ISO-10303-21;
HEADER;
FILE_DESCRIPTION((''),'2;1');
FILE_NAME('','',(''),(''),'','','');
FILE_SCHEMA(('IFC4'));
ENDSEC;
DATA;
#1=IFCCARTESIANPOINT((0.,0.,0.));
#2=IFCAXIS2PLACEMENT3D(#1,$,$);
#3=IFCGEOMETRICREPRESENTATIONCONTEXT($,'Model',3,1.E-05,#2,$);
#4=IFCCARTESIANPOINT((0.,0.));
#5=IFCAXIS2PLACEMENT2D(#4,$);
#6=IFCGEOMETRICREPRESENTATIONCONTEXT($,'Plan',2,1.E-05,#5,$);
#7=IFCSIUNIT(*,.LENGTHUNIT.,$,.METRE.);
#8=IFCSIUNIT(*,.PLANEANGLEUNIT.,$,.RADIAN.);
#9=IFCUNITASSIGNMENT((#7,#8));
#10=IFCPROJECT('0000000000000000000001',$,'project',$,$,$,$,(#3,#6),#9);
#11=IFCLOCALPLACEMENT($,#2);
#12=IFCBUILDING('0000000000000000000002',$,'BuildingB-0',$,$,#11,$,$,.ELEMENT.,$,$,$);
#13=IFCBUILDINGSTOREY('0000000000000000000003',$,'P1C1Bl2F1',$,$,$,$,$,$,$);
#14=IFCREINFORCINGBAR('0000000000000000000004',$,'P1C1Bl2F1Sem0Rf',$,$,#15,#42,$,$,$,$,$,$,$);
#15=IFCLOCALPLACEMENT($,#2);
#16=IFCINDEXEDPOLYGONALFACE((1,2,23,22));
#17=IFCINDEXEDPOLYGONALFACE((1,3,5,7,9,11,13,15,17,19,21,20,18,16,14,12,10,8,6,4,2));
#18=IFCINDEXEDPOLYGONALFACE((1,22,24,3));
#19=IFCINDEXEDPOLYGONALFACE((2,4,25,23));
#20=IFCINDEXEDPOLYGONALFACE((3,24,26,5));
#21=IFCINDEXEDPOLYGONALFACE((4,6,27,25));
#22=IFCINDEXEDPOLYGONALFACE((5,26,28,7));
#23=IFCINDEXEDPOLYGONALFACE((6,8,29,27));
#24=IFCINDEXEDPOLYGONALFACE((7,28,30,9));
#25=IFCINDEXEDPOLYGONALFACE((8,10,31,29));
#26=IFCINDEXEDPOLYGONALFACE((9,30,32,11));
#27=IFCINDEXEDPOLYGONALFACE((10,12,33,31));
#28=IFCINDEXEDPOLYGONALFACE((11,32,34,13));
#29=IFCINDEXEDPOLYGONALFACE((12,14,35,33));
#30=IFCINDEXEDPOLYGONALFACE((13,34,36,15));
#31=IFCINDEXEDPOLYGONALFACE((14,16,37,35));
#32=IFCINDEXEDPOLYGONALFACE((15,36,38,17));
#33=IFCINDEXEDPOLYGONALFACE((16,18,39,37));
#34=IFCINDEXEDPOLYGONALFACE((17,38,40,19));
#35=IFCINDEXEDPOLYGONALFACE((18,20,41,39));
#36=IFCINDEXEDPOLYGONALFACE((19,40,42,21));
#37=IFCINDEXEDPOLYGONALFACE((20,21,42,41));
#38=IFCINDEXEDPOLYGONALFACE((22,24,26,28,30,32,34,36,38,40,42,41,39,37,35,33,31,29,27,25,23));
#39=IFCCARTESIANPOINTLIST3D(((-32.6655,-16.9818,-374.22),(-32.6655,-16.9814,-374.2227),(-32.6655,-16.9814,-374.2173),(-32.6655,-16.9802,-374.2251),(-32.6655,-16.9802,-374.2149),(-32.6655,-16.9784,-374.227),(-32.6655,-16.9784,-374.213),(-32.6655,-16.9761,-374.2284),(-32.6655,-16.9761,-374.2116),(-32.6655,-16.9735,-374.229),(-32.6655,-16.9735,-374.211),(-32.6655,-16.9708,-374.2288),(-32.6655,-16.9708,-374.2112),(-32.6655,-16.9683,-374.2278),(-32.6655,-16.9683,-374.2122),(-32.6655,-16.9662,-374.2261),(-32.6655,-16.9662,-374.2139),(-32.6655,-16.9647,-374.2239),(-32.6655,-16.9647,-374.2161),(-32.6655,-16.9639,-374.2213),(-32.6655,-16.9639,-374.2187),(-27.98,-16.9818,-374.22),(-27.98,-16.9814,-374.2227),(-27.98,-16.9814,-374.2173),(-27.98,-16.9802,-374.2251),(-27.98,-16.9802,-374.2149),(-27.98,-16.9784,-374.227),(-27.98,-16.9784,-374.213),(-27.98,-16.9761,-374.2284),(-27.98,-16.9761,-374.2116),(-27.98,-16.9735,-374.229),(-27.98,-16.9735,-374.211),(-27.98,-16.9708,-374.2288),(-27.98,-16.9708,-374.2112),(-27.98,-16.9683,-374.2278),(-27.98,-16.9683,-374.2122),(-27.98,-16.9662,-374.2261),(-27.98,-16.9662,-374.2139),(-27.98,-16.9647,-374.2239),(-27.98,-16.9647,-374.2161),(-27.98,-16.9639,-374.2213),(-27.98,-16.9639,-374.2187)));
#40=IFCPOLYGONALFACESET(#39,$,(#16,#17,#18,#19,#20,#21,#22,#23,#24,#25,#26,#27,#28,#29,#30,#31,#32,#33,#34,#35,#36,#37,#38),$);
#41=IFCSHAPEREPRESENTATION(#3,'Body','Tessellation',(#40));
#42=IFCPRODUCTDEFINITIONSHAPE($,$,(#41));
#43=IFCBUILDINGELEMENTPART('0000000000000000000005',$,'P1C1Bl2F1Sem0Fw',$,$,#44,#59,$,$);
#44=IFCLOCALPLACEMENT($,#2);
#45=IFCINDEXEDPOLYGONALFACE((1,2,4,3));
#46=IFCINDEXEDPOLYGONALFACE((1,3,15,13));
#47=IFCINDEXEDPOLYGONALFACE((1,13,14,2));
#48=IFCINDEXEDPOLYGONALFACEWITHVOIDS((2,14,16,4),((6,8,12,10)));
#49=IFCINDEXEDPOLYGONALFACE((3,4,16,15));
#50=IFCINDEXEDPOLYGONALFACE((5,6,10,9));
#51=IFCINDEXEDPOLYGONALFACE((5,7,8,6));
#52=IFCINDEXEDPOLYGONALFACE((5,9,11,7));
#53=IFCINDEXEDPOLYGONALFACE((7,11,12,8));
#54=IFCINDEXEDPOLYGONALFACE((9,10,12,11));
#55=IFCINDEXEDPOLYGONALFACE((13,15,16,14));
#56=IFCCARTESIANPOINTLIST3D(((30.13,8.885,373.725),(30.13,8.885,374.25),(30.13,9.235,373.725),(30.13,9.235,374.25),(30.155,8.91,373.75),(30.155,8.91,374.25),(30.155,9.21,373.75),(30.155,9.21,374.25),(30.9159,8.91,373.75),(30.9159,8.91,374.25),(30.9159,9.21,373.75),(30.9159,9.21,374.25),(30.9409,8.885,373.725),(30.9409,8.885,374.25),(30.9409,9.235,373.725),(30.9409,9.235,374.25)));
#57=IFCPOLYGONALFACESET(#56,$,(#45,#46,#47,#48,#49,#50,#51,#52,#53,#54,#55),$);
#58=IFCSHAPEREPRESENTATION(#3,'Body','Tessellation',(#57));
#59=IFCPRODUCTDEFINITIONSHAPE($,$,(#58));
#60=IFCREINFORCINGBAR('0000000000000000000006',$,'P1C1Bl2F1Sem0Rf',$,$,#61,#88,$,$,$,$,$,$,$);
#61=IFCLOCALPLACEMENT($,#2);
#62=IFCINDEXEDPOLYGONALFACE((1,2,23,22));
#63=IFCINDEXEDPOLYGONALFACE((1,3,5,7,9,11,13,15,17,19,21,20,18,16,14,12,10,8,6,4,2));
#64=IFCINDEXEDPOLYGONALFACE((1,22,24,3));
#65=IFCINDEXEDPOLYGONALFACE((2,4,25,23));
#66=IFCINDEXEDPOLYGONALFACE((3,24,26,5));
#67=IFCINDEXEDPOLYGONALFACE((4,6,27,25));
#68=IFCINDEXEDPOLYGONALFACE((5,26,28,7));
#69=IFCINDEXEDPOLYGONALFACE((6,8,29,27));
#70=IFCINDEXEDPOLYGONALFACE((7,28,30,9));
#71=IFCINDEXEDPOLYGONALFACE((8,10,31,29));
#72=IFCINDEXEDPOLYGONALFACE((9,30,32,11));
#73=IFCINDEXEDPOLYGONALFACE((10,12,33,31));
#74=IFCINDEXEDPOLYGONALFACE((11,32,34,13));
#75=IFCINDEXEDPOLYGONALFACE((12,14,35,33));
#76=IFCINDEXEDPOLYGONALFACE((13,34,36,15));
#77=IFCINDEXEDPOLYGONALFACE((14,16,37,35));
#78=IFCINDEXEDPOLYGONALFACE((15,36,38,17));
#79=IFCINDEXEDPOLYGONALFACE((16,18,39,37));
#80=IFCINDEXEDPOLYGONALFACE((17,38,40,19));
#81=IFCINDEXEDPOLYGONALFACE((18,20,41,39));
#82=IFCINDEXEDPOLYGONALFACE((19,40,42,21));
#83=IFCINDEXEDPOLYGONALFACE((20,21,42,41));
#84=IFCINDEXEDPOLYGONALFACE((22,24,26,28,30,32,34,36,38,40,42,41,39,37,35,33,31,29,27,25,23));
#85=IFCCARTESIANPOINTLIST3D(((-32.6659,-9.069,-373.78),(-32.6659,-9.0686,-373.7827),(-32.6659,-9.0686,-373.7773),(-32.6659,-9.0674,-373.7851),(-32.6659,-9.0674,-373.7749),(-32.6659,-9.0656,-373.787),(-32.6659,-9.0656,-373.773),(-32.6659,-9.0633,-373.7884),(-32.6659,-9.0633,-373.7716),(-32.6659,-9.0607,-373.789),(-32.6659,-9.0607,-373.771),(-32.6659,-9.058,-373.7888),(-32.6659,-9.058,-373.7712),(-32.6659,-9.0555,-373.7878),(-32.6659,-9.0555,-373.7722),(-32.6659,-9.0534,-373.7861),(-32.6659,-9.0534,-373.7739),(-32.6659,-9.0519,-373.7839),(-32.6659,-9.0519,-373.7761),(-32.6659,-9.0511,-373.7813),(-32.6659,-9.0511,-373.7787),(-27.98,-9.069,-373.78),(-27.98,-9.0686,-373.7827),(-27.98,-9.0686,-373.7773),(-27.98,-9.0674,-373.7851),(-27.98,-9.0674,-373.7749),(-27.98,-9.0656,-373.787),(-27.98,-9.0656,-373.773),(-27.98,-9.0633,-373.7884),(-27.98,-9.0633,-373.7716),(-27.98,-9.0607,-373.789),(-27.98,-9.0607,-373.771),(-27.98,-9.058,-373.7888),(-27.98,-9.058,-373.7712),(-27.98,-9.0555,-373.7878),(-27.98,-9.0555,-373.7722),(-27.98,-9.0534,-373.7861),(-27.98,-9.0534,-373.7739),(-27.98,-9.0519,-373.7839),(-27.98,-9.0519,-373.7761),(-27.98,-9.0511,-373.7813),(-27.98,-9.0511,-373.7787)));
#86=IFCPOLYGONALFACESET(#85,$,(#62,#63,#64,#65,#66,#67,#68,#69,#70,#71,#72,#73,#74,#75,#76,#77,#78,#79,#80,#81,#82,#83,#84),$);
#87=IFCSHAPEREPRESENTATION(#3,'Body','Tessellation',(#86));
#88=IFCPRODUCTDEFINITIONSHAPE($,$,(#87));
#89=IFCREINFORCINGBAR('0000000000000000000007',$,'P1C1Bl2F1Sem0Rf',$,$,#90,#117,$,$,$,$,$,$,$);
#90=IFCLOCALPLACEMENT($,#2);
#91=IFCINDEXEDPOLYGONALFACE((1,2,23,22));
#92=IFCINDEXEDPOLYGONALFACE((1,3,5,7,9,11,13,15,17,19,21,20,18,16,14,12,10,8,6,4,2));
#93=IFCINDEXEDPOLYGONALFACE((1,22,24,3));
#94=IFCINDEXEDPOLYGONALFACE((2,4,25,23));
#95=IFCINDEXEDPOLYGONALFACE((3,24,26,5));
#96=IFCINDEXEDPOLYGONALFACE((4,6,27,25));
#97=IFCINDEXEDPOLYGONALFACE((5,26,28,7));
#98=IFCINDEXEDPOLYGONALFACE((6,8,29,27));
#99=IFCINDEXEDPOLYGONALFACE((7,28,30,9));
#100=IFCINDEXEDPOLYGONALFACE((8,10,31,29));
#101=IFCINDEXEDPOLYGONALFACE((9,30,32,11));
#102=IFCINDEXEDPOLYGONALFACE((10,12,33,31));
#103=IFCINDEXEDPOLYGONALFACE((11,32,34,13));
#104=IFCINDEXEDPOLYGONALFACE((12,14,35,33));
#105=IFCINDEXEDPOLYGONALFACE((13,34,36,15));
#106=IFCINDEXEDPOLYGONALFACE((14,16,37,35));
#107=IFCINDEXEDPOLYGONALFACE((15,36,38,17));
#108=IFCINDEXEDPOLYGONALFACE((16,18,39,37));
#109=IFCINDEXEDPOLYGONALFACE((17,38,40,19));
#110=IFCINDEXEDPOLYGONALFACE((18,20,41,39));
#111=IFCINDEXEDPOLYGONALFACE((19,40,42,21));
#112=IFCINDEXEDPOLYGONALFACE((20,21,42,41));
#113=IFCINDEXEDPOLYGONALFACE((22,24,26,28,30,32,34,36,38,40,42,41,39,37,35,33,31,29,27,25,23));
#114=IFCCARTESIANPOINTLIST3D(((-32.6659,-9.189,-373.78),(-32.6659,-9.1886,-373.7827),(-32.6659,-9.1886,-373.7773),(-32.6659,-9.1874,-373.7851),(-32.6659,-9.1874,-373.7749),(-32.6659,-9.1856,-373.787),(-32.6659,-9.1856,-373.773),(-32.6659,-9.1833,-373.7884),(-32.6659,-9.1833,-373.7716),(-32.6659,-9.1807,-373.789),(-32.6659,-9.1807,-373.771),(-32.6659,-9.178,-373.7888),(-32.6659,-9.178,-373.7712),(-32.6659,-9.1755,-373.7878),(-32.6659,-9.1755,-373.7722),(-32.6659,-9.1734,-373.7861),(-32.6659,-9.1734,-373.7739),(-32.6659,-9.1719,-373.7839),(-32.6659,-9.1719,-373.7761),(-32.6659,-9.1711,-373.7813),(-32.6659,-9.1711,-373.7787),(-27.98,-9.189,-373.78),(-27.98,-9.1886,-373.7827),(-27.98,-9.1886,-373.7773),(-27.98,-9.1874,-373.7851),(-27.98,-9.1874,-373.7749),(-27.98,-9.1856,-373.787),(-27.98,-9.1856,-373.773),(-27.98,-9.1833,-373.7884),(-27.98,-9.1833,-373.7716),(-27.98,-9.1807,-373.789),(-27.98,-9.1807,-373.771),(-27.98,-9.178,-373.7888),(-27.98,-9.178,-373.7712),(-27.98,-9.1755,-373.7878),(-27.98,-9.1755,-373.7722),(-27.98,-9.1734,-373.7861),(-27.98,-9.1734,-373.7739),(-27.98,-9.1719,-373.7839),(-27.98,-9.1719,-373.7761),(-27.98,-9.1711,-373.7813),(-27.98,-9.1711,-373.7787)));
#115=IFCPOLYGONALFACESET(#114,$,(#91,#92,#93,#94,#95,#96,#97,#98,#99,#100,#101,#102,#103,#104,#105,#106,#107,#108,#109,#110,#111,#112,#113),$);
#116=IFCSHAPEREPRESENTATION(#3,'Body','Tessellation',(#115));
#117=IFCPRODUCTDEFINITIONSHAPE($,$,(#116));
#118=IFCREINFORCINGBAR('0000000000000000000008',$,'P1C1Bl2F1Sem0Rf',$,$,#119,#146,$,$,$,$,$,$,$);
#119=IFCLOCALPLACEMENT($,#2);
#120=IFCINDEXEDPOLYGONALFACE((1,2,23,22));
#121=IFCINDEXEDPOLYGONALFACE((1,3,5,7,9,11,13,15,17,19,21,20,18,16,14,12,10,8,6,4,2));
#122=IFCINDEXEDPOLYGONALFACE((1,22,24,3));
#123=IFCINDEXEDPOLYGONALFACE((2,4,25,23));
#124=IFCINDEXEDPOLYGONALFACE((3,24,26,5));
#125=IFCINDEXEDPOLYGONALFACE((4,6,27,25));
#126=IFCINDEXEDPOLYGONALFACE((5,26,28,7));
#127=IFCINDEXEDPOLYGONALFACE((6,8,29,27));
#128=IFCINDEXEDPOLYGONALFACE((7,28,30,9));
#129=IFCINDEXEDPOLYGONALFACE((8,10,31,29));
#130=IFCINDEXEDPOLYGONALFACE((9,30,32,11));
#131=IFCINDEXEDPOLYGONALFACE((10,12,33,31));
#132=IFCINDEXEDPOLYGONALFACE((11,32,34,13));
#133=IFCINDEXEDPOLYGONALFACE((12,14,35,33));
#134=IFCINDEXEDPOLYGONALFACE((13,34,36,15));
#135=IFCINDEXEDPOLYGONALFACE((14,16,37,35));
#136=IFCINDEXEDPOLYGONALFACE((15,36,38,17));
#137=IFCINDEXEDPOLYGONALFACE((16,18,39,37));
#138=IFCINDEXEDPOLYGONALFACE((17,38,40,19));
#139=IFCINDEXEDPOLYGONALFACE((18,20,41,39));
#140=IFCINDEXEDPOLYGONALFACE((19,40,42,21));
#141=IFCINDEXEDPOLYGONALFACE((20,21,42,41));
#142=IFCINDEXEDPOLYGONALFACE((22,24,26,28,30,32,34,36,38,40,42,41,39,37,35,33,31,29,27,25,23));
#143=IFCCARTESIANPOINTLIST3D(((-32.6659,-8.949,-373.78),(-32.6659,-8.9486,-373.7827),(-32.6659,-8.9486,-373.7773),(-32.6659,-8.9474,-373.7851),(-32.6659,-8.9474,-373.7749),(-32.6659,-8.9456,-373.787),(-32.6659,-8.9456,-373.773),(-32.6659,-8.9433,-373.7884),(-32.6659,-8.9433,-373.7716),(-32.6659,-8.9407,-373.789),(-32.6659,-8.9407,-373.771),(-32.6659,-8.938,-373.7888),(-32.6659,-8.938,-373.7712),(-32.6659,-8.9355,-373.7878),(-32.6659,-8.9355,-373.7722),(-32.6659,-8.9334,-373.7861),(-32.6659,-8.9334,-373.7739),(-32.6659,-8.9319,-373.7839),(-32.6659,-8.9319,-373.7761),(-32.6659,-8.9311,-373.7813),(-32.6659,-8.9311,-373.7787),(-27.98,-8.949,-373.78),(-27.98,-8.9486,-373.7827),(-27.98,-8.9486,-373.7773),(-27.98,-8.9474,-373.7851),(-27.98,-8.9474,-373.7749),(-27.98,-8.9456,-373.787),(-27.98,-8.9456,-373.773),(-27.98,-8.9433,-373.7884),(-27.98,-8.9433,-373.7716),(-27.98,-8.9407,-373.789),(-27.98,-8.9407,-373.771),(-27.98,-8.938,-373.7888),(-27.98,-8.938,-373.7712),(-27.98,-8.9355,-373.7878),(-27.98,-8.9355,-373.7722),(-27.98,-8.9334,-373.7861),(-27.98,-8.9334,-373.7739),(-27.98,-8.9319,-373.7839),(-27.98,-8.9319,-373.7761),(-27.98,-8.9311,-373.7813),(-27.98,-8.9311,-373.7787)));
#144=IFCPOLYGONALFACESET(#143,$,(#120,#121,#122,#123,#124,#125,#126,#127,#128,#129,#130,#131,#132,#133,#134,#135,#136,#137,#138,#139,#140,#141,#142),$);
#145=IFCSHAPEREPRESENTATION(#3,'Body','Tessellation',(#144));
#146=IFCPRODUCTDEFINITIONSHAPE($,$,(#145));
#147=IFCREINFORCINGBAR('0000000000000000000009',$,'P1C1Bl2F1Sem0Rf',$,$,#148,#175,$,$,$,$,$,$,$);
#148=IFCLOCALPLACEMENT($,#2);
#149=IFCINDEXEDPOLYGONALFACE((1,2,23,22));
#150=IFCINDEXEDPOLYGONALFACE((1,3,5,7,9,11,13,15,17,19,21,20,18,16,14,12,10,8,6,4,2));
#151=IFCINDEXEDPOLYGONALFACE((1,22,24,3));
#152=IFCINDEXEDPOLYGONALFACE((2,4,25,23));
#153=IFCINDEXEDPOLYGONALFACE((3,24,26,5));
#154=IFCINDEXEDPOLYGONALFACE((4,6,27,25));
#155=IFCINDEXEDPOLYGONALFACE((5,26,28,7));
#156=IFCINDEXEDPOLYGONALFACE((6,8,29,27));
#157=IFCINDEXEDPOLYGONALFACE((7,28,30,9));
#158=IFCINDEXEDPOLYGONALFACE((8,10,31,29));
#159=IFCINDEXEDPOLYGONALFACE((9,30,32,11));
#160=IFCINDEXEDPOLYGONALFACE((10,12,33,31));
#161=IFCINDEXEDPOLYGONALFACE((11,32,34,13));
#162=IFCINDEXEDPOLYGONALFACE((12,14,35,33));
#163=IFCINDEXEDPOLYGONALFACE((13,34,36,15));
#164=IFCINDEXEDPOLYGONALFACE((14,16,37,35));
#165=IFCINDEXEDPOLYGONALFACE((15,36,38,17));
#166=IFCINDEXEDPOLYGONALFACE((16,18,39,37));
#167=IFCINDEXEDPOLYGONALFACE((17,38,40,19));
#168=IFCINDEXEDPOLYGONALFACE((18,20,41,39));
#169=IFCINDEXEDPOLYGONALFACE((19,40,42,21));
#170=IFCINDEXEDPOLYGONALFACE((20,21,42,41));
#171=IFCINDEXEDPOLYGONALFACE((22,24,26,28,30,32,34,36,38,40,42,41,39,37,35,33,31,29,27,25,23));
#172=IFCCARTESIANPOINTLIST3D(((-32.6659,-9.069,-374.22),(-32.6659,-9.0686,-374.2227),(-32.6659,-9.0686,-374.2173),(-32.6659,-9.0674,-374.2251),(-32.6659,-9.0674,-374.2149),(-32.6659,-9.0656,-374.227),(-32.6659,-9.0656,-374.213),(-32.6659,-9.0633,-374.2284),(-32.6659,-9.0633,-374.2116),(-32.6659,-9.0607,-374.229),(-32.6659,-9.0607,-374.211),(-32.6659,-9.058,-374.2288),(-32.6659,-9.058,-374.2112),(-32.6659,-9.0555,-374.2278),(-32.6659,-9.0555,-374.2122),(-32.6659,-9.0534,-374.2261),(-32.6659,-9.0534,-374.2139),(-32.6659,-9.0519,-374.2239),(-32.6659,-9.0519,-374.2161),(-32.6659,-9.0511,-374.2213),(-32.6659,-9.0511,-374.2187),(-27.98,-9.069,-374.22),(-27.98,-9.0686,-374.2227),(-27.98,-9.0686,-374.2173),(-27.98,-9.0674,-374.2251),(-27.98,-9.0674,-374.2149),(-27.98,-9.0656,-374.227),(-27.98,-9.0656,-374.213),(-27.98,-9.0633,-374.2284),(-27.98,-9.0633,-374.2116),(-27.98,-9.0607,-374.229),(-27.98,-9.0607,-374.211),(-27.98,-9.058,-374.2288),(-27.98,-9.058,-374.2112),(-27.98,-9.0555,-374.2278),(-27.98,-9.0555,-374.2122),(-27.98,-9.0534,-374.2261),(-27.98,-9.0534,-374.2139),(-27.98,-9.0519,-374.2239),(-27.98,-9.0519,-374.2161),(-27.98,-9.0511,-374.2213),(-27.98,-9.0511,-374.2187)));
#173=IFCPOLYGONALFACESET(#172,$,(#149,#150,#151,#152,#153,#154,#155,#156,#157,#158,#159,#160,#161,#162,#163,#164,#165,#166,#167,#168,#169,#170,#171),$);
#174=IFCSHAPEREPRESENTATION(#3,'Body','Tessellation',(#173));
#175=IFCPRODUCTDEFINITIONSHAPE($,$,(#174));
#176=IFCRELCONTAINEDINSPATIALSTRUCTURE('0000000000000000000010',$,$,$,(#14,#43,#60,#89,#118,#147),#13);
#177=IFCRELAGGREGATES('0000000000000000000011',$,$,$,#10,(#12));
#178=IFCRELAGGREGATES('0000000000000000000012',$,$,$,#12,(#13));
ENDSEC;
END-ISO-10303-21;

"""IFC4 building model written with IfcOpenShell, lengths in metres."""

from ifc_helpers import new_model, entity, si_unit, origin, origin_2d, place, context, project, spatial, polyline, outline, extrude, element, save


model = new_model("IFC4")

# Units and contexts
model_context = context("Model", 3, precision=1e-05, world=origin())
plan_context = context("Plan", 2, precision=1e-05, world=origin_2d())
ifc_project = project(units=[si_unit("LENGTHUNIT", "METRE"), si_unit("PLANEANGLEUNIT", "RADIAN")], contexts=[model_context, plan_context])

# Building, storey
building_placement = place(None, origin())
building = spatial("IfcBuilding", under=ifc_project, at=building_placement, Name="BuildingB-0", CompositionType="ELEMENT")
storey = spatial("IfcBuildingStorey", under=building, Name="P1C1Bl2F1")

# Reinforcing bar
element("IfcReinforcingBar", 1, inside=storey, Name="P1C1Bl2F1Sem0Rf", context=model_context, shape_type="SweptSolid", body=[
    entity("IfcSurfaceCurveSweptAreaSolid", entity("IfcCircleProfileDef", "AREA", None, None, 0.009), None, entity("IfcPolyline", [entity("IfcCartesianPoint", [32.6655, 16.9728, 374.22]), entity("IfcCartesianPoint", [27.98, 16.9728, 374.22])]), None, None, entity("IfcPlane", entity("IfcAxis2Placement3D", entity("IfcCartesianPoint", [32.6655, 16.9728, 374.22]), entity("IfcDirection", [0.0, 0.0, 1.0]), entity("IfcDirection", [1.0, 0.0, 0.0])))),
])

# Building element part, opening
building_element_part_1 = element("IfcBuildingElementPart", 2, inside=storey, Name="P1C1Bl2F1Sem0Fw", context=model_context, shape_type="SweptSolid", body=[
    extrude(outline(polyline([(30.13, 8.885, 373.725), (30.9409, 8.885, 373.725), (30.9409, 9.235, 373.725), (30.13, 9.235, 373.725), (30.13, 8.885, 373.725)])), None, (0.0, 0.0, 1.0), 0.525),
])
element("IfcOpeningElement", 3, inside=storey, cuts=building_element_part_1, context=model_context, shape_type="SweptSolid", body=[
    extrude(outline(polyline([(30.155, 8.91, 373.75), (30.9159, 8.91, 373.75), (30.9159, 9.21, 373.75), (30.155, 9.21, 373.75), (30.155, 8.91, 373.75)])), None, (0.0, 0.0, 1.0), 0.5),
])

# Reinforcing bars
element("IfcReinforcingBar", 4, inside=storey, Name="P1C1Bl2F1Sem0Rf", context=model_context, shape_type="SweptSolid", body=[
    entity("IfcSurfaceCurveSweptAreaSolid", entity("IfcCircleProfileDef", "AREA", None, None, 0.009), None, entity("IfcPolyline", [entity("IfcCartesianPoint", [32.6659, 9.06, 373.78]), entity("IfcCartesianPoint", [27.98, 9.06, 373.78])]), None, None, entity("IfcPlane", entity("IfcAxis2Placement3D", entity("IfcCartesianPoint", [32.6659, 9.06, 373.78]), entity("IfcDirection", [0.0, 0.0, 1.0]), entity("IfcDirection", [1.0, 0.0, 0.0])))),
])
element("IfcReinforcingBar", 5, inside=storey, Name="P1C1Bl2F1Sem0Rf", context=model_context, shape_type="SweptSolid", body=[
    entity("IfcSurfaceCurveSweptAreaSolid", entity("IfcCircleProfileDef", "AREA", None, None, 0.009), None, entity("IfcPolyline", [entity("IfcCartesianPoint", [32.6659, 9.18, 373.78]), entity("IfcCartesianPoint", [27.98, 9.18, 373.78])]), None, None, entity("IfcPlane", entity("IfcAxis2Placement3D", entity("IfcCartesianPoint", [32.6659, 9.18, 373.78]), entity("IfcDirection", [0.0, 0.0, 1.0]), entity("IfcDirection", [1.0, 0.0, 0.0])))),
])
element("IfcReinforcingBar", 6, inside=storey, Name="P1C1Bl2F1Sem0Rf", context=model_context, shape_type="SweptSolid", body=[
    entity("IfcSurfaceCurveSweptAreaSolid", entity("IfcCircleProfileDef", "AREA", None, None, 0.009), None, entity("IfcPolyline", [entity("IfcCartesianPoint", [32.6659, 8.94, 373.78]), entity("IfcCartesianPoint", [27.98, 8.94, 373.78])]), None, None, entity("IfcPlane", entity("IfcAxis2Placement3D", entity("IfcCartesianPoint", [32.6659, 8.94, 373.78]), entity("IfcDirection", [0.0, 0.0, 1.0]), entity("IfcDirection", [1.0, 0.0, 0.0])))),
])
element("IfcReinforcingBar", 7, inside=storey, Name="P1C1Bl2F1Sem0Rf", context=model_context, shape_type="SweptSolid", body=[
    entity("IfcSurfaceCurveSweptAreaSolid", entity("IfcCircleProfileDef", "AREA", None, None, 0.009), None, entity("IfcPolyline", [entity("IfcCartesianPoint", [32.6659, 9.06, 374.22]), entity("IfcCartesianPoint", [27.98, 9.06, 374.22])]), None, None, entity("IfcPlane", entity("IfcAxis2Placement3D", entity("IfcCartesianPoint", [32.6659, 9.06, 374.22]), entity("IfcDirection", [0.0, 0.0, 1.0]), entity("IfcDirection", [1.0, 0.0, 0.0])))),
])

save(model, "model.ifc")
